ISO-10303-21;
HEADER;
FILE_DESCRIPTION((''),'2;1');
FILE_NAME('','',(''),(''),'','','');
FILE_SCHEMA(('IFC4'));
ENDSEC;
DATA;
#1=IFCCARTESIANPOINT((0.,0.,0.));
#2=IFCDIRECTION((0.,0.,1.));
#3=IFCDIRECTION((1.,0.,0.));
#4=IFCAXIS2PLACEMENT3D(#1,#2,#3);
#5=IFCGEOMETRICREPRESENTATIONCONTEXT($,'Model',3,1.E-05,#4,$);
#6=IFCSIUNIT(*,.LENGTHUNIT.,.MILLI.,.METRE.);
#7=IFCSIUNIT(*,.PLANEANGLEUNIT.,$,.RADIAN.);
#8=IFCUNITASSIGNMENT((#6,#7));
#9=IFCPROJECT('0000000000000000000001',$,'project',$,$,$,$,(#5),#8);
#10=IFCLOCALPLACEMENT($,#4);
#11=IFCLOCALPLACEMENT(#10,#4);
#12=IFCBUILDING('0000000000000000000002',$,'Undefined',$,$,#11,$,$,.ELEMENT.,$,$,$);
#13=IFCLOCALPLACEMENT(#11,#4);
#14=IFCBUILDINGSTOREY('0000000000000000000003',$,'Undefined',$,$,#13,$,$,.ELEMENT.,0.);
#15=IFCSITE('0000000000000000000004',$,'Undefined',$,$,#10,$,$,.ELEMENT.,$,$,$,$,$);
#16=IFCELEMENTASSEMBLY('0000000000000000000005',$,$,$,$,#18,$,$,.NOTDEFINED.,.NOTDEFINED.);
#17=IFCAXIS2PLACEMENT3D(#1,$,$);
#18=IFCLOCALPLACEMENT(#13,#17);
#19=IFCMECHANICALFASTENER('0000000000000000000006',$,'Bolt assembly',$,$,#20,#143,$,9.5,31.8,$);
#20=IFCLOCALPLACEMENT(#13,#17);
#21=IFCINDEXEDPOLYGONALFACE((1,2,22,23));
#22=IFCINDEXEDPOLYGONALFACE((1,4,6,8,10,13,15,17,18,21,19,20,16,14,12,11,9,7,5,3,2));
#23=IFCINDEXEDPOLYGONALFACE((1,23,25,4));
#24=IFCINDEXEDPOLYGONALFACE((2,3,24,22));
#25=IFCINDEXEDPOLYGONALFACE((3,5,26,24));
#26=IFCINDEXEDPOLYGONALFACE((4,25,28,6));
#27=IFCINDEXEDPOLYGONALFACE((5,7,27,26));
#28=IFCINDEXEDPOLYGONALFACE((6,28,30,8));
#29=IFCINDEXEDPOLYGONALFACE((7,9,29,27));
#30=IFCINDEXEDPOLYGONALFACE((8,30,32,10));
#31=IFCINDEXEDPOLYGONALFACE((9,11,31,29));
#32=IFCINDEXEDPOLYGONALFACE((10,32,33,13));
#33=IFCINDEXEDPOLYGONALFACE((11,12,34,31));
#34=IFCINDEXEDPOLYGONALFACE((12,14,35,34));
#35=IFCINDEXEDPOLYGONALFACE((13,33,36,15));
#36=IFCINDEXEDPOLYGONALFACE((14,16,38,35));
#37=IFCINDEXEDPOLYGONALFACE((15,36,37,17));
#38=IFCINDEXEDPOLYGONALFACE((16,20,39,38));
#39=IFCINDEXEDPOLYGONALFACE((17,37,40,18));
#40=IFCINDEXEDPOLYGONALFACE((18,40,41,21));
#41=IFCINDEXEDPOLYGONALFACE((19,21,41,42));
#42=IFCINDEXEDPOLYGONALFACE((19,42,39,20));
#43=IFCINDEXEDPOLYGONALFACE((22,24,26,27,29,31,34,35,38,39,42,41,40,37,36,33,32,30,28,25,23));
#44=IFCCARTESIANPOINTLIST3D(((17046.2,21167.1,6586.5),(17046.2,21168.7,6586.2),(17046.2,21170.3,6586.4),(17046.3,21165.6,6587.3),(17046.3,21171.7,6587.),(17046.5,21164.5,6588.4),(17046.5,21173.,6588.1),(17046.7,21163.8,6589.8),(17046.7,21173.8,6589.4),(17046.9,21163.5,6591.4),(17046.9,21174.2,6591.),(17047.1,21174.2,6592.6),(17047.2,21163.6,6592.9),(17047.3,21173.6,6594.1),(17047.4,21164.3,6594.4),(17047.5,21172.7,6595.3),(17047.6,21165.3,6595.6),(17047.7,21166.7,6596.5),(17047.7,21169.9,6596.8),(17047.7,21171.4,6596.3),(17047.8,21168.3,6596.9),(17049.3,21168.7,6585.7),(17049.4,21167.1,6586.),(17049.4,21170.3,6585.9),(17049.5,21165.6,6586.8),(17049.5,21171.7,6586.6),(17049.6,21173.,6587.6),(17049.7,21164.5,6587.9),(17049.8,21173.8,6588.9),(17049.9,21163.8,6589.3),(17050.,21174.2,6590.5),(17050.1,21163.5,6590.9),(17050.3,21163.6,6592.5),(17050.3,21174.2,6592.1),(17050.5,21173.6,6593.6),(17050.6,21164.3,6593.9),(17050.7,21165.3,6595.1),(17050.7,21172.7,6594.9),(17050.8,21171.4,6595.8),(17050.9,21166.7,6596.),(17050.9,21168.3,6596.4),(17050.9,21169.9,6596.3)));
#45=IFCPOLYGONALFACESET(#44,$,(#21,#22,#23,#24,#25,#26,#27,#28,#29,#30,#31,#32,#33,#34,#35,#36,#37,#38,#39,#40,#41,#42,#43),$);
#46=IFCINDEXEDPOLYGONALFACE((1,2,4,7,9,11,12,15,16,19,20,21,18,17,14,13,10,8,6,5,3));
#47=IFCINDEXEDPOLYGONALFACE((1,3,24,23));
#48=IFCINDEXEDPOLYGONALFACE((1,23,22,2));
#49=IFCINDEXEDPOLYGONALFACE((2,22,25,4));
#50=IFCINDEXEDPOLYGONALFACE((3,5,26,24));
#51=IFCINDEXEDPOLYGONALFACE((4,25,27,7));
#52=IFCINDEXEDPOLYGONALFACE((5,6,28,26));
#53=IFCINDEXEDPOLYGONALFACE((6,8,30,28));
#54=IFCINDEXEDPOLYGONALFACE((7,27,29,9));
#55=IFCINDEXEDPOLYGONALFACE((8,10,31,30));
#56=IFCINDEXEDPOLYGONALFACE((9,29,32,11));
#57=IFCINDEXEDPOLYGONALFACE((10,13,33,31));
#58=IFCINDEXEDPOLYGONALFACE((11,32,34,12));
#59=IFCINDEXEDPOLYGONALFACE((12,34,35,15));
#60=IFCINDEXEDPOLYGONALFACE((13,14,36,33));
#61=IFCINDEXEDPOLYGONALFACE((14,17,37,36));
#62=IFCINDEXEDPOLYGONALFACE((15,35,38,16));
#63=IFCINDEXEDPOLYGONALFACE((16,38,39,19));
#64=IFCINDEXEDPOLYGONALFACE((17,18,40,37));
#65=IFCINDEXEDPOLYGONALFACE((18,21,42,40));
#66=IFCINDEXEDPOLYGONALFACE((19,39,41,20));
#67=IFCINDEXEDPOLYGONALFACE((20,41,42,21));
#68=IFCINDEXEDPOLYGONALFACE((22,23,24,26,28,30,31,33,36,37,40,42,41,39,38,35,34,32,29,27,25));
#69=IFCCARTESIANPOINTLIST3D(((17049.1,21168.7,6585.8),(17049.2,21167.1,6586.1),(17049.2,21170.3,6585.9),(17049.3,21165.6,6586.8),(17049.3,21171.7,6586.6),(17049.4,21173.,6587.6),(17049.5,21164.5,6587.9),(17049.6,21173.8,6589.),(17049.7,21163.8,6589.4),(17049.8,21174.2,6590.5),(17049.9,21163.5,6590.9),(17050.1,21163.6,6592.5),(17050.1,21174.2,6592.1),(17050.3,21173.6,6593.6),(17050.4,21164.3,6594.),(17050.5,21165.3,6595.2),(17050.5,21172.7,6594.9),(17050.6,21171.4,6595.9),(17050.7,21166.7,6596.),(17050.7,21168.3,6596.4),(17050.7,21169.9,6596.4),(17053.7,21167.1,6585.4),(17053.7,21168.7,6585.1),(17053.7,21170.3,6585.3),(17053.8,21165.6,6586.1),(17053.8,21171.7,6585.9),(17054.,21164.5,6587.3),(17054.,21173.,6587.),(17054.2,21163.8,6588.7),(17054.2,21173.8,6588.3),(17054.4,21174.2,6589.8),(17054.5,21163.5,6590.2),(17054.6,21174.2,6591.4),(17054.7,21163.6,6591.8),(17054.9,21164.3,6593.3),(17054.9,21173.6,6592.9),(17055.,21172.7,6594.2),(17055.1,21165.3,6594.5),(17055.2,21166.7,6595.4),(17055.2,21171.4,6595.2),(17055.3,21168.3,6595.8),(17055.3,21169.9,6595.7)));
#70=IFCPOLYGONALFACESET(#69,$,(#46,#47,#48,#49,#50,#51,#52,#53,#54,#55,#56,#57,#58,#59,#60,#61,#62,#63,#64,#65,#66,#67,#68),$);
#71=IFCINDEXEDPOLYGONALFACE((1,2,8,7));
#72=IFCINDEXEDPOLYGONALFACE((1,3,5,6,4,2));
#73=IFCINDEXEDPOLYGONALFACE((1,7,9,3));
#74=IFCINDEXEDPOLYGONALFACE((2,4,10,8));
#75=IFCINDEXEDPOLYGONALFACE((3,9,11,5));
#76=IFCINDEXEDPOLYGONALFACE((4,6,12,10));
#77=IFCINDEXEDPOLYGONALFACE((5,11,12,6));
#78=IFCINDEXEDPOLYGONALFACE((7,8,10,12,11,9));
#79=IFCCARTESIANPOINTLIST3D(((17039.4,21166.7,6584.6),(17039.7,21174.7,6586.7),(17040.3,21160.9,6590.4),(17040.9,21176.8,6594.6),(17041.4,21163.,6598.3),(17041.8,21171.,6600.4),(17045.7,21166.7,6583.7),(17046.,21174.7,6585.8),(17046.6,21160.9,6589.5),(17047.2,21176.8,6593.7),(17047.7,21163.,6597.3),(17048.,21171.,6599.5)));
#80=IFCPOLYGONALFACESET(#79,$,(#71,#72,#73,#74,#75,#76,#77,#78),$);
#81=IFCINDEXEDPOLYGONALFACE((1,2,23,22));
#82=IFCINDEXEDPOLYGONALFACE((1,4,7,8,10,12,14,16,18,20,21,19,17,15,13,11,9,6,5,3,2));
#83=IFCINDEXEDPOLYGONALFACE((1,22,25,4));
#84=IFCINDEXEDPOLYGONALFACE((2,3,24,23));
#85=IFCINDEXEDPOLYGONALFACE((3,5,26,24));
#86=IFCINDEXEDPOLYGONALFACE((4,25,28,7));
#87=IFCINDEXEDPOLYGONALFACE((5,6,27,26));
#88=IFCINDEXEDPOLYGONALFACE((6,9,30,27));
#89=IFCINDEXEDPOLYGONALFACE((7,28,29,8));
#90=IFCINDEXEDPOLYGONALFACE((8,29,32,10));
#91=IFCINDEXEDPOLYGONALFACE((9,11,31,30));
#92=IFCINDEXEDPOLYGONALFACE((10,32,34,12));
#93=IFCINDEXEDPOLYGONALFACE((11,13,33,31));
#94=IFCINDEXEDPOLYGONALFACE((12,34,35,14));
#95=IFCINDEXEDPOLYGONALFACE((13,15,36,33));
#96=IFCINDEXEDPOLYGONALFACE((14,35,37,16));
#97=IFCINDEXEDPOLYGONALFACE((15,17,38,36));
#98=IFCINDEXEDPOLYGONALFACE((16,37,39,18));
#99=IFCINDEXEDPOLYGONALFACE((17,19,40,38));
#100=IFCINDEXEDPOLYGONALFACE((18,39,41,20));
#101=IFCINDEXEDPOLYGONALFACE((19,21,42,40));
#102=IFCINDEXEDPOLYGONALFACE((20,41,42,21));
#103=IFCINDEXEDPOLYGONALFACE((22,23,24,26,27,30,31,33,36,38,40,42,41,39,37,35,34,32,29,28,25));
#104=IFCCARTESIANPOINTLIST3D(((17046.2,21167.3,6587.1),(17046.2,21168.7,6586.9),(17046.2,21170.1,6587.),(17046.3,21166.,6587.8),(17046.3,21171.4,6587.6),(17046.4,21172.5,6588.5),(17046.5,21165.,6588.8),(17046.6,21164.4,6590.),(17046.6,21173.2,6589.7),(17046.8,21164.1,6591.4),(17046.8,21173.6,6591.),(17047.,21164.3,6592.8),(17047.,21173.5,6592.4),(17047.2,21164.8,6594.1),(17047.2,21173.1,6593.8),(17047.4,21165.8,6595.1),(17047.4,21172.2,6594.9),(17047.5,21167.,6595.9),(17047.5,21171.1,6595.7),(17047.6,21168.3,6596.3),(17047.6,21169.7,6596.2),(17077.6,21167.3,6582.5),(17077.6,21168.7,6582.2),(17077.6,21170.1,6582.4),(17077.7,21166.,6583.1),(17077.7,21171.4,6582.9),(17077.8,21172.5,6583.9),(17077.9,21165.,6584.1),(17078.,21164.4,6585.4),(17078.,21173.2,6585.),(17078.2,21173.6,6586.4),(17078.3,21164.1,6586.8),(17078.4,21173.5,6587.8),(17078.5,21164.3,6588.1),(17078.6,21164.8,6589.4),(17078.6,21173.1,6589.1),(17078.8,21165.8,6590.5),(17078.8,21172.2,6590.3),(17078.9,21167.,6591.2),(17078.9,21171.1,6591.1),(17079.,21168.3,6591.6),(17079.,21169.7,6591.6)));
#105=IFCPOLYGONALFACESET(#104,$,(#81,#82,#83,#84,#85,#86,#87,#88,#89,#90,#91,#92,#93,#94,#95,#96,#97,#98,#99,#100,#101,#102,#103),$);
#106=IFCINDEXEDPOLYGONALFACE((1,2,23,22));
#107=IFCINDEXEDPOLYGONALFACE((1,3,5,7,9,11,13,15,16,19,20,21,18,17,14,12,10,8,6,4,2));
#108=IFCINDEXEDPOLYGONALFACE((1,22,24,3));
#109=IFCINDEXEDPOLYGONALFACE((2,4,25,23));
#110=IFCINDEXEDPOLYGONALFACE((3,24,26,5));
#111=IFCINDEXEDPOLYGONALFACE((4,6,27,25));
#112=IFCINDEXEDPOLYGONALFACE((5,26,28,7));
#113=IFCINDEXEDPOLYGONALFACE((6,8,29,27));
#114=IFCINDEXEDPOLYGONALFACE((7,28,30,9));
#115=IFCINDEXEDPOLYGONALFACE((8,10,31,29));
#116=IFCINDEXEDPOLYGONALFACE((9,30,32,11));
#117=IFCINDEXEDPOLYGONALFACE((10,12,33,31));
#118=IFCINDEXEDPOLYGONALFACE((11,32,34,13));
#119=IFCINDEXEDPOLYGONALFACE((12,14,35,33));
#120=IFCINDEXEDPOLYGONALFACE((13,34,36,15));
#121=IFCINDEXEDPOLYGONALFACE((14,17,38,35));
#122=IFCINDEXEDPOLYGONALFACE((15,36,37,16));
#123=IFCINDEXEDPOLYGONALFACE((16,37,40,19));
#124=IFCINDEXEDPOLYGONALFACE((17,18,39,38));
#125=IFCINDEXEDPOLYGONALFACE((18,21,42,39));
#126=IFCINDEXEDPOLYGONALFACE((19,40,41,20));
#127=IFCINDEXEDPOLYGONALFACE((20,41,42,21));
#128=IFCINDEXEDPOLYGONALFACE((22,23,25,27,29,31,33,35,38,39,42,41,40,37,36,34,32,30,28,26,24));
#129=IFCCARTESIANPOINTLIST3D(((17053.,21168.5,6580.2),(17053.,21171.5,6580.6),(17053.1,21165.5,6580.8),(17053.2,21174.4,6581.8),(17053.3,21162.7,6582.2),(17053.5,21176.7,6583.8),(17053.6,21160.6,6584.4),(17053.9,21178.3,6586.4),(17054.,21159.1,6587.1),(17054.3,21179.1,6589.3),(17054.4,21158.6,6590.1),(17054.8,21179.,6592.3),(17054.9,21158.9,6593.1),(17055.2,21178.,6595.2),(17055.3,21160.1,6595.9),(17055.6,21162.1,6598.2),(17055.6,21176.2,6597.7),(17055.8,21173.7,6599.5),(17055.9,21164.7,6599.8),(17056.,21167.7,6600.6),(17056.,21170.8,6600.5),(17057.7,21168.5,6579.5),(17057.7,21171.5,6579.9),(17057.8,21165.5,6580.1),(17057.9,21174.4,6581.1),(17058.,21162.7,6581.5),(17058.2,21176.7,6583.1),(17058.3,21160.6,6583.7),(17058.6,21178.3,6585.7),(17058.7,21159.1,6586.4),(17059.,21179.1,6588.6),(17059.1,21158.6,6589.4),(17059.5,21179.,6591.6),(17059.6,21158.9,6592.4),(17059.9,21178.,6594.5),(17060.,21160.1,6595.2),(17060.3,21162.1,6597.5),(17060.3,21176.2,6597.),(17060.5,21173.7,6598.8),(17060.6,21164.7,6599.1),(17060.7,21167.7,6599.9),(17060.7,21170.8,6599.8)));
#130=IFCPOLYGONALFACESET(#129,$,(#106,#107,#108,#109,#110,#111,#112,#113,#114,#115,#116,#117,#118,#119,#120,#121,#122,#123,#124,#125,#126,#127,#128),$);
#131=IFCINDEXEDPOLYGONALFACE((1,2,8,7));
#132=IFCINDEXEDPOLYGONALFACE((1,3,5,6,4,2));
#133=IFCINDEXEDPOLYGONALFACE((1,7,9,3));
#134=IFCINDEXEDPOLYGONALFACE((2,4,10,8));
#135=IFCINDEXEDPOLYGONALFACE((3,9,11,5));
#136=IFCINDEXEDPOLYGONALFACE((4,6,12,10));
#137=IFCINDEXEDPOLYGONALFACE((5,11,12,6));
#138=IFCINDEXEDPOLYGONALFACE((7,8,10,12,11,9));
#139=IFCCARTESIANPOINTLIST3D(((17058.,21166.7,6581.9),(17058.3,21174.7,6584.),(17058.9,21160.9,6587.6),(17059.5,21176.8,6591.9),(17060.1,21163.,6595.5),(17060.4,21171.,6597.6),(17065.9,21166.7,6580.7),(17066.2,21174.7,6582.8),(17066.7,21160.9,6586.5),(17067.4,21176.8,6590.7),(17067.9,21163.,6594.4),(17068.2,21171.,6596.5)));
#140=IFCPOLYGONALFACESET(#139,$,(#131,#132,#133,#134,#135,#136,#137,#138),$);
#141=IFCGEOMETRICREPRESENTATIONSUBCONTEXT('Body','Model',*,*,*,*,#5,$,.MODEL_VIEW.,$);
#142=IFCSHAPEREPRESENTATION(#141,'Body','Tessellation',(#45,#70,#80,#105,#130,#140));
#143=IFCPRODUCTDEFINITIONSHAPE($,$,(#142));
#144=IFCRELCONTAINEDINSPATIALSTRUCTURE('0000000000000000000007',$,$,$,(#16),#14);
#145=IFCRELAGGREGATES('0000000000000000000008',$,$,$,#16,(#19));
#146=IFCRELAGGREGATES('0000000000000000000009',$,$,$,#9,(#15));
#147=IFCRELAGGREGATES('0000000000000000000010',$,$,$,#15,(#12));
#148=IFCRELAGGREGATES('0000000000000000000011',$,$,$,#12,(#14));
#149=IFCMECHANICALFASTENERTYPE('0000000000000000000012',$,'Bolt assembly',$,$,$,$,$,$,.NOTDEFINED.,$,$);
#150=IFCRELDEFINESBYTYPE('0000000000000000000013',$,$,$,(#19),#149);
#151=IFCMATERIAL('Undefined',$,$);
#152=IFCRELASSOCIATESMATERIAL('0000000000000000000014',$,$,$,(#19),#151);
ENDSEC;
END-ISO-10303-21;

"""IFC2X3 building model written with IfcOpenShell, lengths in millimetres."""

from ifc_helpers import new_model, si_unit, frame, origin_with_axes, origin_2d_with_axis, place, context, subcontext, project, spatial, polyline, circle, outline, extrude, source, transform, mapped, material, type_object, element, aggregate, save


model = new_model("IFC2X3")

# Units and contexts
model_context = context("Model", 3, precision=1e-05, world=origin_with_axes())
body_context = subcontext(model_context, "Body", "Model", "MODEL_VIEW")
ifc_project = project(units=[si_unit("LENGTHUNIT", "METRE", prefix="MILLI"), si_unit("PLANEANGLEUNIT", "RADIAN")], contexts=[model_context])

# Site, building, storey
site_placement = place(None, origin_with_axes())
site = spatial("IfcSite", under=ifc_project, at=site_placement, Name="Undefined", CompositionType="ELEMENT")
building_placement = place(site_placement, origin_with_axes())
building = spatial("IfcBuilding", under=site, at=building_placement, Name="Undefined", CompositionType="ELEMENT")
storey_placement = place(building_placement, origin_with_axes())
storey = spatial("IfcBuildingStorey", under=building, at=storey_placement, Name="Undefined", CompositionType="ELEMENT", Elevation=0.0)

# Element assembly
assembly_1_placement = place(storey_placement, origin_with_axes())
assembly_1 = element("IfcElementAssembly", 1, at=assembly_1_placement, inside=storey, AssemblyPlace="NOTDEFINED", PredefinedType="NOTDEFINED")

# Shared definitions
ifc_material_1 = material(Name="Undefined")
mechanical_fastener_type = type_object("IfcMechanicalFastenerType", Name="Bolt assembly")

# Mechanical fastener
shared_shape_1 = source(origin_with_axes(), body_context, "Body", "SweptSolid", [
    extrude(circle(Radius=5.4, at=origin_2d_with_axis()), frame((0.0, -3.1, 0.0), z_axis=(0.0, 1.0, 0.0), x_axis=(1.0, 0.0, 0.0)), (0.0, 0.0, 1.0), 3.2),
    extrude(circle(Radius=5.4, at=origin_2d_with_axis()), frame((0.0, -0.1, 0.0), z_axis=(0.0, 1.0, 0.0), x_axis=(1.0, 0.0, 0.0)), (0.0, 0.0, 1.0), 4.6),
    extrude(outline(polyline([(7.1, -4.1), (7.1, 4.1), (0.0, 8.2), (-7.1, 4.1), (-7.1, -4.1), (0.0, -8.2), (7.1, -4.1)])), frame((0.0, -9.6, 0.0), z_axis=(0.0, 1.0, 0.0), x_axis=(1.0, 0.0, 0.0)), (0.0, 0.0, 1.0), 6.3),
    extrude(circle(Radius=4.8, at=origin_2d_with_axis()), frame((0.0, -3.2, 0.0), z_axis=(0.0, 1.0, 0.0), x_axis=(1.0, 0.0, 0.0)), (0.0, 0.0, 1.0), 31.8),
    extrude(circle(Radius=10.3, at=origin_2d_with_axis()), frame((0.0, 4.5, 0.0), z_axis=(0.0, 1.0, 0.0), x_axis=(1.0, 0.0, 0.0)), (0.0, 0.0, 1.0), 4.8),
    extrude(outline(polyline([(7.1, -4.1), (7.1, 4.1), (0.0, 8.2), (-7.1, 4.1), (-7.1, -4.1), (0.0, -8.2), (7.1, -4.1)])), frame((0.0, 9.3, 0.0), z_axis=(0.0, 1.0, 0.0), x_axis=(1.0, 0.0, 0.0)), (0.0, 0.0, 1.0), 7.9),
])
mechanical_fastener_1_placement = place(assembly_1_placement, frame((17050.0, 21168.9, 6591.1), z_axis=(-0.10338, 0.707107, -0.699509), x_axis=(0.10338, 0.707107, 0.699509)))
mechanical_fastener_1 = element("IfcMechanicalFastener", 2, at=mechanical_fastener_1_placement, type_object=mechanical_fastener_type, material=ifc_material_1, Name="Bolt assembly", NominalDiameter=9.5, NominalLength=31.8, context=body_context, shape_type="MappedRepresentation", body=[
    mapped(shared_shape_1, transform((0.0, 0.0, 0.0))),
])
aggregate(assembly_1, [mechanical_fastener_1])

save(model, "model.ifc")
